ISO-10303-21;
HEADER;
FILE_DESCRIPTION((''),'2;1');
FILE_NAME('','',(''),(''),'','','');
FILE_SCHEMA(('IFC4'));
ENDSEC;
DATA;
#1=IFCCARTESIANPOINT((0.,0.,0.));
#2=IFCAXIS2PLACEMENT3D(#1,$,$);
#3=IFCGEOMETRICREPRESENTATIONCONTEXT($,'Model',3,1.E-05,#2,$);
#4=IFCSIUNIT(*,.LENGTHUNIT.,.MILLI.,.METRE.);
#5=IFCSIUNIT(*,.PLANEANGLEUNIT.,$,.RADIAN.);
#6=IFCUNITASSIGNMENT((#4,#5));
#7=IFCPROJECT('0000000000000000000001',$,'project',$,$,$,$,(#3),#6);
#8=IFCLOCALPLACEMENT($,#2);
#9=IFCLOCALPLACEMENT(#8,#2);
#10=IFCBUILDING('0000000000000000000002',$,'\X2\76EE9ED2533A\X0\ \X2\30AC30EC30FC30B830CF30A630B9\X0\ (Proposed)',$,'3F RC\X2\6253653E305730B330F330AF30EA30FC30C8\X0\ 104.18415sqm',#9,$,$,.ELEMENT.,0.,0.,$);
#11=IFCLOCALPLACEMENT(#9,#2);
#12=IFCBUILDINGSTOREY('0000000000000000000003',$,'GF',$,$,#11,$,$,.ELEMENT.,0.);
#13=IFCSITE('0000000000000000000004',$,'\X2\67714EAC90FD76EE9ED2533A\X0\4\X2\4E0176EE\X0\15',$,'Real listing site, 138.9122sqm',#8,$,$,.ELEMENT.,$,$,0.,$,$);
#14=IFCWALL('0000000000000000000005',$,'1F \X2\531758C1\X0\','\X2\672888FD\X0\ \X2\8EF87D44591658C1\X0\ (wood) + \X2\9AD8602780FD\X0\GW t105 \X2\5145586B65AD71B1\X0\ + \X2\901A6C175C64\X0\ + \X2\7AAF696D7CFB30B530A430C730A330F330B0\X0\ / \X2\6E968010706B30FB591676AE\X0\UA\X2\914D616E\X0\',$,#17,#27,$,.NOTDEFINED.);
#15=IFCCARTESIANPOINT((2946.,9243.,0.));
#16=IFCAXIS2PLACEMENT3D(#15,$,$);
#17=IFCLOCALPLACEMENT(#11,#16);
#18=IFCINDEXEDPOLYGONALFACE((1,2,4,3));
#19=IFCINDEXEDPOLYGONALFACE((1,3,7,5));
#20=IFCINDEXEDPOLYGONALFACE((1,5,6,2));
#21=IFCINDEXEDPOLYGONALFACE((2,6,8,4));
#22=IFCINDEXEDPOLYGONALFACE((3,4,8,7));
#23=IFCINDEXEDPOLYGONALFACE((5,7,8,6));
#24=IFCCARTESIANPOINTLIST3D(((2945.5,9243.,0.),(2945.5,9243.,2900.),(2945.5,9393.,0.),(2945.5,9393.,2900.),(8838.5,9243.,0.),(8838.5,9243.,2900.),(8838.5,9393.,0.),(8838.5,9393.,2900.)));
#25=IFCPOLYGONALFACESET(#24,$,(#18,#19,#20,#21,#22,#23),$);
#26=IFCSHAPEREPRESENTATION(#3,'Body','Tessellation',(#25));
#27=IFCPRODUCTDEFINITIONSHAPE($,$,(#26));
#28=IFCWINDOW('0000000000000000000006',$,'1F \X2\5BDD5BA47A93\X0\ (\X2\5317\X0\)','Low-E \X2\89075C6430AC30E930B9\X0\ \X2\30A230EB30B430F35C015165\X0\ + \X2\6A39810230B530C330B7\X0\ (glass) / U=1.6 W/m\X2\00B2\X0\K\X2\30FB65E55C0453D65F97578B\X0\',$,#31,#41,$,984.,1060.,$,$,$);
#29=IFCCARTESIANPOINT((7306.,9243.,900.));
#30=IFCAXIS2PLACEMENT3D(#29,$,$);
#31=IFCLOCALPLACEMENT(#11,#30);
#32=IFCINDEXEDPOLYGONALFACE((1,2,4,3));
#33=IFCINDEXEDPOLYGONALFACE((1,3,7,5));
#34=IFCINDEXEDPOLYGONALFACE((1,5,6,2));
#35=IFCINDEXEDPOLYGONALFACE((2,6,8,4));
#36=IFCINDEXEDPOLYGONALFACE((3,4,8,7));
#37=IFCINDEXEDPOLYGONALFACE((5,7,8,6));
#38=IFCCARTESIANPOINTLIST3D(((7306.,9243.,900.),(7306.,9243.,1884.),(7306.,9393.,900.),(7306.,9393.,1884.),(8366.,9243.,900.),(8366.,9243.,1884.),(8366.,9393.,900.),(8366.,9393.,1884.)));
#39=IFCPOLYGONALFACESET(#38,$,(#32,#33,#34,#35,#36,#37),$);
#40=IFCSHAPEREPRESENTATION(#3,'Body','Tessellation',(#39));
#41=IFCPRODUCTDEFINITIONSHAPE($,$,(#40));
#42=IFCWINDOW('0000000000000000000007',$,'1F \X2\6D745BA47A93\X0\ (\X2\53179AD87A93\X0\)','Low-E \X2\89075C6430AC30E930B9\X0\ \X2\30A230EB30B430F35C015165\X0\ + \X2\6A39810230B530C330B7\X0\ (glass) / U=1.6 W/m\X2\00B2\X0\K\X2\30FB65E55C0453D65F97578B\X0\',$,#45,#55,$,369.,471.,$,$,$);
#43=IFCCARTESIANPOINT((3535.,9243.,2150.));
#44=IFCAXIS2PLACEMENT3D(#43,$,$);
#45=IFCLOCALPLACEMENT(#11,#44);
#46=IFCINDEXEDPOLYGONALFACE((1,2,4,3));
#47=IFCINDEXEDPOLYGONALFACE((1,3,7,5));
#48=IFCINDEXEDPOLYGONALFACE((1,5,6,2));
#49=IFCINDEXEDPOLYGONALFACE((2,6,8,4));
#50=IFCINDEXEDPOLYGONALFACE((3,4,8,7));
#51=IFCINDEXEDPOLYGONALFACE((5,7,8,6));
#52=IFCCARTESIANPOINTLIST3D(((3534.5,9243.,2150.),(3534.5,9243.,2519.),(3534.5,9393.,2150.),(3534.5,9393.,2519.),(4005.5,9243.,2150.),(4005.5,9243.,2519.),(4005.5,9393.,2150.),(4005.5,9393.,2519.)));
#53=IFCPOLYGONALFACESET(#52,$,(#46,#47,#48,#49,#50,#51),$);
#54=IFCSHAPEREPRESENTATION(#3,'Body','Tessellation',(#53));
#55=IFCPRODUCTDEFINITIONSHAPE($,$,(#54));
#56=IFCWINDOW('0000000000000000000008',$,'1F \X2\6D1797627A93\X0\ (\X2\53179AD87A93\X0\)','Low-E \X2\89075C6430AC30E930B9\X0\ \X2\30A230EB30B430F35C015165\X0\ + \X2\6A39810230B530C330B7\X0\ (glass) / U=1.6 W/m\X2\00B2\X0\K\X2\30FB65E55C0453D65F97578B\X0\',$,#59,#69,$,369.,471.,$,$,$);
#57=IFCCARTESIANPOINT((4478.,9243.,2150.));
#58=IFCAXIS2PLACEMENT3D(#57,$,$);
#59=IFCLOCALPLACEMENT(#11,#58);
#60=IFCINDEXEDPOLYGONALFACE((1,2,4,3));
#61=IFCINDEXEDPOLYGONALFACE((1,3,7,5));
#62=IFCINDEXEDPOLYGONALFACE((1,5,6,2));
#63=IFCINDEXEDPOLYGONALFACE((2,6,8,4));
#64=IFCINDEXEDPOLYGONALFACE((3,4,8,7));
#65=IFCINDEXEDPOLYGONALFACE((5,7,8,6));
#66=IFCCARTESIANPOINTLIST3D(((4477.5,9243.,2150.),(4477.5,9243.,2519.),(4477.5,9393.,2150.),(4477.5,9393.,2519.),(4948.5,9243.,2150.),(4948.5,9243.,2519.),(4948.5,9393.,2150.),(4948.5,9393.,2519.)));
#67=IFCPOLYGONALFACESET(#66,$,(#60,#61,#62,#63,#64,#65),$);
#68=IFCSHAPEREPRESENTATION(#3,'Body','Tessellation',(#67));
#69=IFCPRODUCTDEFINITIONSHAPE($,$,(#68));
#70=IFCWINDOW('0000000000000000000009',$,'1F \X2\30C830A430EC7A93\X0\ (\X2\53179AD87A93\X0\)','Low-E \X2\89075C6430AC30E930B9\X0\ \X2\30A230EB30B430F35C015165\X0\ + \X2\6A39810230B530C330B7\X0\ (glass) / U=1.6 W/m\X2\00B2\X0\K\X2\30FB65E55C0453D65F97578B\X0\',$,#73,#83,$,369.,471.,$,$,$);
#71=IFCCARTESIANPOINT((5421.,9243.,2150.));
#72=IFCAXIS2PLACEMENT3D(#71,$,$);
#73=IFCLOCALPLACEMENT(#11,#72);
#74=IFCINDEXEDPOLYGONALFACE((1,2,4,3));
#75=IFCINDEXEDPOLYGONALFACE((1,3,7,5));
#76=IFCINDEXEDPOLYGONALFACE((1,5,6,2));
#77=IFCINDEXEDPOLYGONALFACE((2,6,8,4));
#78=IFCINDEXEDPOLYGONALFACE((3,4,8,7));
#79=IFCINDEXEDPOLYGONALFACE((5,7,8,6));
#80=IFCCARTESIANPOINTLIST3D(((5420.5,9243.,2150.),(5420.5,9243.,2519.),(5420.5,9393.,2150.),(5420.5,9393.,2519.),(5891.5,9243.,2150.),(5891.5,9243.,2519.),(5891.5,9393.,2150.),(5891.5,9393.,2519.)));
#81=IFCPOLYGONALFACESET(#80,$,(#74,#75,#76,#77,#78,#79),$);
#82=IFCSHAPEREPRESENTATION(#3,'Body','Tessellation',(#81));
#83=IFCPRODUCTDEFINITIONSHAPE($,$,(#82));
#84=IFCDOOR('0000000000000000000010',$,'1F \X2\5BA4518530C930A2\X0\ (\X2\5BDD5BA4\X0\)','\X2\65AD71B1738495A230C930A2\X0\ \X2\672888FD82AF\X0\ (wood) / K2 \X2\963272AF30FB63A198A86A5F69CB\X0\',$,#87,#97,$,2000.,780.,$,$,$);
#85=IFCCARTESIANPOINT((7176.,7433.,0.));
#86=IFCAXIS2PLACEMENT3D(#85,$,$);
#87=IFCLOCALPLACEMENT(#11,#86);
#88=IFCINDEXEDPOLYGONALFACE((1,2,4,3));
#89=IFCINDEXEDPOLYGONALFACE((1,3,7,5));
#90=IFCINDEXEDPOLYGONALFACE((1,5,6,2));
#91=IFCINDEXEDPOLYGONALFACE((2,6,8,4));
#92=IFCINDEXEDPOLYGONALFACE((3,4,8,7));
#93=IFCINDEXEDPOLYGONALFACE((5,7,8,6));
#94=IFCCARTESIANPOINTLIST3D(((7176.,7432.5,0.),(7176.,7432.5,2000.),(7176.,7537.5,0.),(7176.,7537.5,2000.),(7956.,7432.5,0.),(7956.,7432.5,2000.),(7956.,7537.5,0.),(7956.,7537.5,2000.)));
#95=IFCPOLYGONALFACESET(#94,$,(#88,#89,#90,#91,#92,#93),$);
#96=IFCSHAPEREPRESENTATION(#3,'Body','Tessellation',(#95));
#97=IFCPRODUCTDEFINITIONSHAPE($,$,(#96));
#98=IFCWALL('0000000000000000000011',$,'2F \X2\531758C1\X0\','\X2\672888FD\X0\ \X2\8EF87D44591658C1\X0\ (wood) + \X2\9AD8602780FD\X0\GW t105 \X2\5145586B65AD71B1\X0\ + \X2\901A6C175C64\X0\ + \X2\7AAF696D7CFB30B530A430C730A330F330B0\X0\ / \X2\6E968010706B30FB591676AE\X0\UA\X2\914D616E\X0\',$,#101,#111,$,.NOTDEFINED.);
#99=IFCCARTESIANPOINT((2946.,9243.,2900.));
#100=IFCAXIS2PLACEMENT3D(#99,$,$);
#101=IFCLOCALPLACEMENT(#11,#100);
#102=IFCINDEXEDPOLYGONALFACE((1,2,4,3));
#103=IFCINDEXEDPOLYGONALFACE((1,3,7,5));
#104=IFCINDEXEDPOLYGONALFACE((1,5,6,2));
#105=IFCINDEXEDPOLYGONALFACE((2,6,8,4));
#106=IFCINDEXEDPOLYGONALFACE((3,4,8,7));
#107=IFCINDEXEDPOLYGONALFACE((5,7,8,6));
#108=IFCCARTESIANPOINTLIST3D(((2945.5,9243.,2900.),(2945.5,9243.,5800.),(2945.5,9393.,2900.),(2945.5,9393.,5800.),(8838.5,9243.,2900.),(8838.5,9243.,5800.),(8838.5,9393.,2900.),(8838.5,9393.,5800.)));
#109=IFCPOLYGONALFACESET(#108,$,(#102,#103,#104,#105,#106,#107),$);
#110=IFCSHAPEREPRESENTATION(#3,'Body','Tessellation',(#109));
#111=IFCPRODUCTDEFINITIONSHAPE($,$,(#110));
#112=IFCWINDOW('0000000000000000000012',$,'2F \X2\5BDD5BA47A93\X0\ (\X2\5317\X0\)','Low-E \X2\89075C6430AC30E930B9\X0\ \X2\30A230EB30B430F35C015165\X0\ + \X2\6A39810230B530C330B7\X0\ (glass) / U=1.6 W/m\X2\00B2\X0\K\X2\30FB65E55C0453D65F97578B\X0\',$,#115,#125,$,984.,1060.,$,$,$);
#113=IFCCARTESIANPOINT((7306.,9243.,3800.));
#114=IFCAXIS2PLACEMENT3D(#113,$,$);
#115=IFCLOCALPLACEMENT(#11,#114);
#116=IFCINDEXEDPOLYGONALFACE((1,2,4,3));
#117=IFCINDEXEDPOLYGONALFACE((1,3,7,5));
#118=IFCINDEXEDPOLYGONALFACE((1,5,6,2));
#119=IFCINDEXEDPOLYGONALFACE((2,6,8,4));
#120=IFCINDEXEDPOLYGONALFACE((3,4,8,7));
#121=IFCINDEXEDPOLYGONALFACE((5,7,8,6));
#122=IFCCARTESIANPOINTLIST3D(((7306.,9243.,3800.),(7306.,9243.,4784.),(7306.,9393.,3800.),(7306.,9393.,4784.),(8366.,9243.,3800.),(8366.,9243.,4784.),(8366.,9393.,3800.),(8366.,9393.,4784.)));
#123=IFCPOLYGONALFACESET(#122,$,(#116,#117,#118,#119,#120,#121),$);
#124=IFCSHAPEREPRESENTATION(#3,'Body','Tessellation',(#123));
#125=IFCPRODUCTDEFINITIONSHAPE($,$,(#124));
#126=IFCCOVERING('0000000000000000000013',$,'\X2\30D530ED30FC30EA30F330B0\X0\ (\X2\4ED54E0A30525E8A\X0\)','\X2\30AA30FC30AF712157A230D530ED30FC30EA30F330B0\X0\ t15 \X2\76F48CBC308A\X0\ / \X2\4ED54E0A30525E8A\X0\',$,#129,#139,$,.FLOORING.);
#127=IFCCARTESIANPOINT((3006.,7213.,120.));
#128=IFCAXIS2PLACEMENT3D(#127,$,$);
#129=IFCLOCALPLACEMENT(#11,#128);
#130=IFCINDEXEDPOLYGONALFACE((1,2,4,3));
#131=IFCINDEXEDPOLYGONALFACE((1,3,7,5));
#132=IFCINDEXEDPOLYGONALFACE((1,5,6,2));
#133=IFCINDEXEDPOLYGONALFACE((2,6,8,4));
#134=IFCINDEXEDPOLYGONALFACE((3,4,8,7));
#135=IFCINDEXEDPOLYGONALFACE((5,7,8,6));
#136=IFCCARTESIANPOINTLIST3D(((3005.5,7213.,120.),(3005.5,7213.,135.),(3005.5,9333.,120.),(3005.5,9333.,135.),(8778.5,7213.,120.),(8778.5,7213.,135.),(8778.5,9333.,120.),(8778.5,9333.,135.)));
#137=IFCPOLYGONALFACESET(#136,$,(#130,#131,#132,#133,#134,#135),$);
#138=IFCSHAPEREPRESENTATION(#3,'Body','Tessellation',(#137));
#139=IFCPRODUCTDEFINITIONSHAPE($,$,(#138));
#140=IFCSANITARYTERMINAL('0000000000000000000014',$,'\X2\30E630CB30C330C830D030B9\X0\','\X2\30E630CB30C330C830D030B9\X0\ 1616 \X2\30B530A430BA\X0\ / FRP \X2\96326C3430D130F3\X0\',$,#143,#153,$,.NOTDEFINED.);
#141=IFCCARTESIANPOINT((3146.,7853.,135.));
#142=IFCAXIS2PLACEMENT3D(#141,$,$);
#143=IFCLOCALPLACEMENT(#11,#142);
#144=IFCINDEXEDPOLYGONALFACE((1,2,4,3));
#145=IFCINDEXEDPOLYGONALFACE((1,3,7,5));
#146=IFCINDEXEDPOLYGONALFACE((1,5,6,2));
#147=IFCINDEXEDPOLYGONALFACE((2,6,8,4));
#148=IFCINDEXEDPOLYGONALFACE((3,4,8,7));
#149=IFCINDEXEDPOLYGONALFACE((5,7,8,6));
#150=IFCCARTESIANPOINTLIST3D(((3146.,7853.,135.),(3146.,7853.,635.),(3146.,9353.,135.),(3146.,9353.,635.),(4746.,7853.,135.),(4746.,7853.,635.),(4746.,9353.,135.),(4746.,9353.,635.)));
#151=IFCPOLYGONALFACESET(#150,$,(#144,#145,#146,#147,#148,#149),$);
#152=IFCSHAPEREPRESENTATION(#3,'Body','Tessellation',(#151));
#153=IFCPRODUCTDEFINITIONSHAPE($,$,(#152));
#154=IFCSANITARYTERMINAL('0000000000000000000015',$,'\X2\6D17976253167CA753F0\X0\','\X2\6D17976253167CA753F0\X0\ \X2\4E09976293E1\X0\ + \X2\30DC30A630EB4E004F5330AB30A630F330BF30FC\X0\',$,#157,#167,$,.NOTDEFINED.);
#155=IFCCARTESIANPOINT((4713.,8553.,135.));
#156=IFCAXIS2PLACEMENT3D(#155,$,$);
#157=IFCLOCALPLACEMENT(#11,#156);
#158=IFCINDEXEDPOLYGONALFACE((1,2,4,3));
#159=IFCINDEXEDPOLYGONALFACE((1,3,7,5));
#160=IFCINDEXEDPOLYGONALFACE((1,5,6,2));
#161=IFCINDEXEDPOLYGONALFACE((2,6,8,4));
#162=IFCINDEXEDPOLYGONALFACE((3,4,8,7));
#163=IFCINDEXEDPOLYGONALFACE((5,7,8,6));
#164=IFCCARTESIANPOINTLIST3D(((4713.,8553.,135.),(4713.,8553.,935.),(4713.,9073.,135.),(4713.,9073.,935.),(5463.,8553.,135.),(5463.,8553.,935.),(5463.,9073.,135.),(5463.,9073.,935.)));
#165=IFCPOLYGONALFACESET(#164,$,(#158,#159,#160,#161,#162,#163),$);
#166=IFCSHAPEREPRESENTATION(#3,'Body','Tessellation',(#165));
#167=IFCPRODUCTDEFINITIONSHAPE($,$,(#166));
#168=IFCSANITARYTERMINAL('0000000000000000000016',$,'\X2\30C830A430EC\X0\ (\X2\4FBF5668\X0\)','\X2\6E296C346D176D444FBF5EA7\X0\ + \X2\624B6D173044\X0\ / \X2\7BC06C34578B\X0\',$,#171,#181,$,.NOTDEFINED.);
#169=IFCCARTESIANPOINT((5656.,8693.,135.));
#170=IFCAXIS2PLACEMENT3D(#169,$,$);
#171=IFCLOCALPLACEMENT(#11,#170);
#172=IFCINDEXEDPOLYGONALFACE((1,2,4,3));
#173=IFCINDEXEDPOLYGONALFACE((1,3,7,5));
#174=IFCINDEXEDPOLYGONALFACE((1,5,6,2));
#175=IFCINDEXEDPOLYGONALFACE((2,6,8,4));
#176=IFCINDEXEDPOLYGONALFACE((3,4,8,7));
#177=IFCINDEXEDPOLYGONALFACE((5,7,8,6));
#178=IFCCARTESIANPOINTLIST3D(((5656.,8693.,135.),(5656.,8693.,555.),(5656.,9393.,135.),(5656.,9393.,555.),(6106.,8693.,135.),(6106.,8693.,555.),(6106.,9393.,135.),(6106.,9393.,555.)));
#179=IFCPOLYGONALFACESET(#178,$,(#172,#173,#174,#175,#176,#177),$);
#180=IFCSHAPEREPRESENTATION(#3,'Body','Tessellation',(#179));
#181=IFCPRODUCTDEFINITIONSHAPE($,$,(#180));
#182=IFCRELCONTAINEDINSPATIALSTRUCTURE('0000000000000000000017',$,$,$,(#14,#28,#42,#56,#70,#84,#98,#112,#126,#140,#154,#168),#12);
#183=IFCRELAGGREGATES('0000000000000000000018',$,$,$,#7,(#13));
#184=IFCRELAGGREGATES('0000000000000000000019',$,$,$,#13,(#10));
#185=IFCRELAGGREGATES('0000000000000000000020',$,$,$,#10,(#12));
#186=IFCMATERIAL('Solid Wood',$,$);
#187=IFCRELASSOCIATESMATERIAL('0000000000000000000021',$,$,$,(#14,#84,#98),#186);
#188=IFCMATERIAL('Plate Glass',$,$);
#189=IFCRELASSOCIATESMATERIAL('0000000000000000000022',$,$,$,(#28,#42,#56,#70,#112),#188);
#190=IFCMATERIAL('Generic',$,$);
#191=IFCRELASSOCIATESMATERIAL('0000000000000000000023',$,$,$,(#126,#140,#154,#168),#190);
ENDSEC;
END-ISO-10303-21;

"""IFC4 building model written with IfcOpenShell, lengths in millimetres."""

from ifc_helpers import new_model, si_unit, frame, frame_2d, origin, place, context, project, spatial, rectangle, extrude, material, element, fill, save


model = new_model("IFC4")

# Units and contexts
model_context = context("Model", 3, precision=1e-05, world=origin())
ifc_project = project(units=[si_unit("LENGTHUNIT", "METRE", prefix="MILLI"), si_unit("PLANEANGLEUNIT", "RADIAN")], contexts=[model_context])

# Site, building, storey
site_placement = place(None, origin())
site = spatial("IfcSite", under=ifc_project, at=site_placement, Name="東京都目黒区4丁目15", ObjectType="Real listing site, 138.9122sqm", CompositionType="ELEMENT", RefElevation=0.0)
building_placement = place(site_placement, origin())
building = spatial("IfcBuilding", under=site, at=building_placement, Name="目黒区 ガレージハウス (Proposed)", ObjectType="3F RC打放しコンクリート 104.18415sqm", CompositionType="ELEMENT", ElevationOfRefHeight=0.0, ElevationOfTerrain=0.0)
storey_placement = place(building_placement, origin())
storey = spatial("IfcBuildingStorey", under=building, at=storey_placement, Name="GF", CompositionType="ELEMENT", Elevation=0.0)

# Wall, openings, windows
ifc_material_1 = material(Name="Solid Wood")
wall_1_placement = place(storey_placement, frame((2946.0, 9243.0, 0.0)))
wall_1 = element("IfcWall", 1, at=wall_1_placement, inside=storey, material=ifc_material_1, Name="1F 北壁", Description="木製 軸組外壁 (wood) + 高性能GW t105 充填断熱 + 通気層 + 窯業系サイディング / 準耐火・外皮UA配慮", PredefinedType="NOTDEFINED", context=model_context, shape_type="SweptSolid", body=[
    extrude(rectangle(XDim=5893.0, YDim=150.0, at=frame_2d((2946.0, 75.0))), frame((2946.0, 9243.0, 0.0)), (0.0, 0.0, 1.0), 2900.0),
])
opening_1_placement = place(storey_placement, frame((7306.0, 9243.0, 900.0)))
opening_1 = element("IfcOpeningElement", 2, at=opening_1_placement, cuts=wall_1, PredefinedType="NOTDEFINED", context=model_context, shape_type="SweptSolid", body=[
    extrude(rectangle(XDim=1060.0, YDim=150.0, at=frame_2d((530.0, 75.0))), frame((7306.0, 9243.0, 900.0)), (0.0, 0.0, 1.0), 984.0),
])
opening_2_placement = place(storey_placement, frame((3535.0, 9243.0, 2150.0)))
opening_2 = element("IfcOpeningElement", 3, at=opening_2_placement, cuts=wall_1, PredefinedType="NOTDEFINED", context=model_context, shape_type="SweptSolid", body=[
    extrude(rectangle(XDim=471.0, YDim=150.0, at=frame_2d((235.0, 75.0))), frame((3535.0, 9243.0, 2150.0)), (0.0, 0.0, 1.0), 369.0),
])
opening_3_placement = place(storey_placement, frame((4478.0, 9243.0, 2150.0)))
opening_3 = element("IfcOpeningElement", 4, at=opening_3_placement, cuts=wall_1, PredefinedType="NOTDEFINED", context=model_context, shape_type="SweptSolid", body=[
    extrude(rectangle(XDim=471.0, YDim=150.0, at=frame_2d((235.0, 75.0))), frame((4478.0, 9243.0, 2150.0)), (0.0, 0.0, 1.0), 369.0),
])
opening_4_placement = place(storey_placement, frame((5421.0, 9243.0, 2150.0)))
opening_4 = element("IfcOpeningElement", 5, at=opening_4_placement, cuts=wall_1, PredefinedType="NOTDEFINED", context=model_context, shape_type="SweptSolid", body=[
    extrude(rectangle(XDim=471.0, YDim=150.0, at=frame_2d((235.0, 75.0))), frame((5421.0, 9243.0, 2150.0)), (0.0, 0.0, 1.0), 369.0),
])
ifc_material_2 = material(Name="Plate Glass")
window_1_placement = place(storey_placement, frame((7306.0, 9243.0, 900.0)))
window_1 = element("IfcWindow", 6, at=window_1_placement, inside=storey, material=ifc_material_2, Name="1F 寝室窓 (北)", Description="Low-E 複層ガラス アルゴン封入 + 樹脂サッシ (glass) / U=1.6 W/m²K・日射取得型", OverallHeight=984.0, OverallWidth=1060.0, context=model_context, shape_type="SweptSolid", body=[
    extrude(rectangle(XDim=1060.0, YDim=150.0, at=frame_2d((530.0, 75.0))), frame((7306.0, 9243.0, 900.0)), (0.0, 0.0, 1.0), 984.0),
])
fill(opening_1, window_1)
window_2_placement = place(storey_placement, frame((3535.0, 9243.0, 2150.0)))
window_2 = element("IfcWindow", 7, at=window_2_placement, inside=storey, material=ifc_material_2, Name="1F 浴室窓 (北高窓)", Description="Low-E 複層ガラス アルゴン封入 + 樹脂サッシ (glass) / U=1.6 W/m²K・日射取得型", OverallHeight=369.0, OverallWidth=471.0, context=model_context, shape_type="SweptSolid", body=[
    extrude(rectangle(XDim=471.0, YDim=150.0, at=frame_2d((235.0, 75.0))), frame((3535.0, 9243.0, 2150.0)), (0.0, 0.0, 1.0), 369.0),
])
fill(opening_2, window_2)
window_3_placement = place(storey_placement, frame((4478.0, 9243.0, 2150.0)))
window_3 = element("IfcWindow", 8, at=window_3_placement, inside=storey, material=ifc_material_2, Name="1F 洗面窓 (北高窓)", Description="Low-E 複層ガラス アルゴン封入 + 樹脂サッシ (glass) / U=1.6 W/m²K・日射取得型", OverallHeight=369.0, OverallWidth=471.0, context=model_context, shape_type="SweptSolid", body=[
    extrude(rectangle(XDim=471.0, YDim=150.0, at=frame_2d((235.0, 75.0))), frame((4478.0, 9243.0, 2150.0)), (0.0, 0.0, 1.0), 369.0),
])
fill(opening_3, window_3)
window_4_placement = place(storey_placement, frame((5421.0, 9243.0, 2150.0)))
window_4 = element("IfcWindow", 9, at=window_4_placement, inside=storey, material=ifc_material_2, Name="1F トイレ窓 (北高窓)", Description="Low-E 複層ガラス アルゴン封入 + 樹脂サッシ (glass) / U=1.6 W/m²K・日射取得型", OverallHeight=369.0, OverallWidth=471.0, context=model_context, shape_type="SweptSolid", body=[
    extrude(rectangle(XDim=471.0, YDim=150.0, at=frame_2d((235.0, 75.0))), frame((5421.0, 9243.0, 2150.0)), (0.0, 0.0, 1.0), 369.0),
])
fill(opening_4, window_4)

# Door
door_1_placement = place(storey_placement, frame((7176.0, 7433.0, 0.0)))
element("IfcDoor", 10, at=door_1_placement, inside=storey, material=ifc_material_1, Name="1F 室内ドア (寝室)", Description="断熱玄関ドア 木製芯 (wood) / K2 防犯・採風機構", OverallHeight=2000.0, OverallWidth=780.0, context=model_context, shape_type="SweptSolid", body=[
    extrude(rectangle(XDim=780.0, YDim=105.0, at=frame_2d((390.0, 52.0))), frame((7176.0, 7433.0, 0.0)), (0.0, 0.0, 1.0), 2000.0),
])

# Wall, opening, window
wall_2_placement = place(storey_placement, frame((2946.0, 9243.0, 2900.0)))
wall_2 = element("IfcWall", 11, at=wall_2_placement, inside=storey, material=ifc_material_1, Name="2F 北壁", Description="木製 軸組外壁 (wood) + 高性能GW t105 充填断熱 + 通気層 + 窯業系サイディング / 準耐火・外皮UA配慮", PredefinedType="NOTDEFINED", context=model_context, shape_type="SweptSolid", body=[
    extrude(rectangle(XDim=5893.0, YDim=150.0, at=frame_2d((2946.0, 75.0))), frame((2946.0, 9243.0, 2900.0)), (0.0, 0.0, 1.0), 2900.0),
])
opening_5_placement = place(storey_placement, frame((7306.0, 9243.0, 3800.0)))
opening_5 = element("IfcOpeningElement", 12, at=opening_5_placement, cuts=wall_2, PredefinedType="NOTDEFINED", context=model_context, shape_type="SweptSolid", body=[
    extrude(rectangle(XDim=1060.0, YDim=150.0, at=frame_2d((530.0, 75.0))), frame((7306.0, 9243.0, 3800.0)), (0.0, 0.0, 1.0), 984.0),
])
window_5_placement = place(storey_placement, frame((7306.0, 9243.0, 3800.0)))
window_5 = element("IfcWindow", 13, at=window_5_placement, inside=storey, material=ifc_material_2, Name="2F 寝室窓 (北)", Description="Low-E 複層ガラス アルゴン封入 + 樹脂サッシ (glass) / U=1.6 W/m²K・日射取得型", OverallHeight=984.0, OverallWidth=1060.0, context=model_context, shape_type="SweptSolid", body=[
    extrude(rectangle(XDim=1060.0, YDim=150.0, at=frame_2d((530.0, 75.0))), frame((7306.0, 9243.0, 3800.0)), (0.0, 0.0, 1.0), 984.0),
])
fill(opening_5, window_5)

# Covering
ifc_material_3 = material(Name="Generic")
covering_placement = place(storey_placement, frame((3006.0, 7213.0, 120.0)))
element("IfcCovering", 14, at=covering_placement, inside=storey, material=ifc_material_3, Name="フローリング (仕上げ床)", Description="オーク無垢フローリング t15 直貼り / 仕上げ床", PredefinedType="FLOORING", context=model_context, shape_type="SweptSolid", body=[
    extrude(rectangle(XDim=5773.0, YDim=2120.0, at=frame_2d((2886.0, 1060.0))), frame((3006.0, 7213.0, 120.0)), (0.0, 0.0, 1.0), 15.0),
])

# Sanitary terminals
sanitary_terminal_1_placement = place(storey_placement, frame((3146.0, 7853.0, 135.0)))
element("IfcSanitaryTerminal", 15, at=sanitary_terminal_1_placement, inside=storey, material=ifc_material_3, Name="ユニットバス", Description="ユニットバス 1616 サイズ / FRP 防水パン", PredefinedType="NOTDEFINED", context=model_context, shape_type="SweptSolid", body=[
    extrude(rectangle(XDim=1600.0, YDim=1500.0, at=frame_2d((800.0, 750.0))), frame((3146.0, 7853.0, 135.0)), (0.0, 0.0, 1.0), 500.0),
])
sanitary_terminal_2_placement = place(storey_placement, frame((4713.0, 8553.0, 135.0)))
element("IfcSanitaryTerminal", 16, at=sanitary_terminal_2_placement, inside=storey, material=ifc_material_3, Name="洗面化粧台", Description="洗面化粧台 三面鏡 + ボウル一体カウンター", PredefinedType="NOTDEFINED", context=model_context, shape_type="SweptSolid", body=[
    extrude(rectangle(XDim=750.0, YDim=520.0, at=frame_2d((375.0, 260.0))), frame((4713.0, 8553.0, 135.0)), (0.0, 0.0, 1.0), 800.0),
])
sanitary_terminal_3_placement = place(storey_placement, frame((5656.0, 8693.0, 135.0)))
element("IfcSanitaryTerminal", 17, at=sanitary_terminal_3_placement, inside=storey, material=ifc_material_3, Name="トイレ (便器)", Description="温水洗浄便座 + 手洗い / 節水型", PredefinedType="NOTDEFINED", context=model_context, shape_type="SweptSolid", body=[
    extrude(rectangle(XDim=450.0, YDim=700.0, at=frame_2d((225.0, 350.0))), frame((5656.0, 8693.0, 135.0)), (0.0, 0.0, 1.0), 420.0),
])

save(model, "model.ifc")
